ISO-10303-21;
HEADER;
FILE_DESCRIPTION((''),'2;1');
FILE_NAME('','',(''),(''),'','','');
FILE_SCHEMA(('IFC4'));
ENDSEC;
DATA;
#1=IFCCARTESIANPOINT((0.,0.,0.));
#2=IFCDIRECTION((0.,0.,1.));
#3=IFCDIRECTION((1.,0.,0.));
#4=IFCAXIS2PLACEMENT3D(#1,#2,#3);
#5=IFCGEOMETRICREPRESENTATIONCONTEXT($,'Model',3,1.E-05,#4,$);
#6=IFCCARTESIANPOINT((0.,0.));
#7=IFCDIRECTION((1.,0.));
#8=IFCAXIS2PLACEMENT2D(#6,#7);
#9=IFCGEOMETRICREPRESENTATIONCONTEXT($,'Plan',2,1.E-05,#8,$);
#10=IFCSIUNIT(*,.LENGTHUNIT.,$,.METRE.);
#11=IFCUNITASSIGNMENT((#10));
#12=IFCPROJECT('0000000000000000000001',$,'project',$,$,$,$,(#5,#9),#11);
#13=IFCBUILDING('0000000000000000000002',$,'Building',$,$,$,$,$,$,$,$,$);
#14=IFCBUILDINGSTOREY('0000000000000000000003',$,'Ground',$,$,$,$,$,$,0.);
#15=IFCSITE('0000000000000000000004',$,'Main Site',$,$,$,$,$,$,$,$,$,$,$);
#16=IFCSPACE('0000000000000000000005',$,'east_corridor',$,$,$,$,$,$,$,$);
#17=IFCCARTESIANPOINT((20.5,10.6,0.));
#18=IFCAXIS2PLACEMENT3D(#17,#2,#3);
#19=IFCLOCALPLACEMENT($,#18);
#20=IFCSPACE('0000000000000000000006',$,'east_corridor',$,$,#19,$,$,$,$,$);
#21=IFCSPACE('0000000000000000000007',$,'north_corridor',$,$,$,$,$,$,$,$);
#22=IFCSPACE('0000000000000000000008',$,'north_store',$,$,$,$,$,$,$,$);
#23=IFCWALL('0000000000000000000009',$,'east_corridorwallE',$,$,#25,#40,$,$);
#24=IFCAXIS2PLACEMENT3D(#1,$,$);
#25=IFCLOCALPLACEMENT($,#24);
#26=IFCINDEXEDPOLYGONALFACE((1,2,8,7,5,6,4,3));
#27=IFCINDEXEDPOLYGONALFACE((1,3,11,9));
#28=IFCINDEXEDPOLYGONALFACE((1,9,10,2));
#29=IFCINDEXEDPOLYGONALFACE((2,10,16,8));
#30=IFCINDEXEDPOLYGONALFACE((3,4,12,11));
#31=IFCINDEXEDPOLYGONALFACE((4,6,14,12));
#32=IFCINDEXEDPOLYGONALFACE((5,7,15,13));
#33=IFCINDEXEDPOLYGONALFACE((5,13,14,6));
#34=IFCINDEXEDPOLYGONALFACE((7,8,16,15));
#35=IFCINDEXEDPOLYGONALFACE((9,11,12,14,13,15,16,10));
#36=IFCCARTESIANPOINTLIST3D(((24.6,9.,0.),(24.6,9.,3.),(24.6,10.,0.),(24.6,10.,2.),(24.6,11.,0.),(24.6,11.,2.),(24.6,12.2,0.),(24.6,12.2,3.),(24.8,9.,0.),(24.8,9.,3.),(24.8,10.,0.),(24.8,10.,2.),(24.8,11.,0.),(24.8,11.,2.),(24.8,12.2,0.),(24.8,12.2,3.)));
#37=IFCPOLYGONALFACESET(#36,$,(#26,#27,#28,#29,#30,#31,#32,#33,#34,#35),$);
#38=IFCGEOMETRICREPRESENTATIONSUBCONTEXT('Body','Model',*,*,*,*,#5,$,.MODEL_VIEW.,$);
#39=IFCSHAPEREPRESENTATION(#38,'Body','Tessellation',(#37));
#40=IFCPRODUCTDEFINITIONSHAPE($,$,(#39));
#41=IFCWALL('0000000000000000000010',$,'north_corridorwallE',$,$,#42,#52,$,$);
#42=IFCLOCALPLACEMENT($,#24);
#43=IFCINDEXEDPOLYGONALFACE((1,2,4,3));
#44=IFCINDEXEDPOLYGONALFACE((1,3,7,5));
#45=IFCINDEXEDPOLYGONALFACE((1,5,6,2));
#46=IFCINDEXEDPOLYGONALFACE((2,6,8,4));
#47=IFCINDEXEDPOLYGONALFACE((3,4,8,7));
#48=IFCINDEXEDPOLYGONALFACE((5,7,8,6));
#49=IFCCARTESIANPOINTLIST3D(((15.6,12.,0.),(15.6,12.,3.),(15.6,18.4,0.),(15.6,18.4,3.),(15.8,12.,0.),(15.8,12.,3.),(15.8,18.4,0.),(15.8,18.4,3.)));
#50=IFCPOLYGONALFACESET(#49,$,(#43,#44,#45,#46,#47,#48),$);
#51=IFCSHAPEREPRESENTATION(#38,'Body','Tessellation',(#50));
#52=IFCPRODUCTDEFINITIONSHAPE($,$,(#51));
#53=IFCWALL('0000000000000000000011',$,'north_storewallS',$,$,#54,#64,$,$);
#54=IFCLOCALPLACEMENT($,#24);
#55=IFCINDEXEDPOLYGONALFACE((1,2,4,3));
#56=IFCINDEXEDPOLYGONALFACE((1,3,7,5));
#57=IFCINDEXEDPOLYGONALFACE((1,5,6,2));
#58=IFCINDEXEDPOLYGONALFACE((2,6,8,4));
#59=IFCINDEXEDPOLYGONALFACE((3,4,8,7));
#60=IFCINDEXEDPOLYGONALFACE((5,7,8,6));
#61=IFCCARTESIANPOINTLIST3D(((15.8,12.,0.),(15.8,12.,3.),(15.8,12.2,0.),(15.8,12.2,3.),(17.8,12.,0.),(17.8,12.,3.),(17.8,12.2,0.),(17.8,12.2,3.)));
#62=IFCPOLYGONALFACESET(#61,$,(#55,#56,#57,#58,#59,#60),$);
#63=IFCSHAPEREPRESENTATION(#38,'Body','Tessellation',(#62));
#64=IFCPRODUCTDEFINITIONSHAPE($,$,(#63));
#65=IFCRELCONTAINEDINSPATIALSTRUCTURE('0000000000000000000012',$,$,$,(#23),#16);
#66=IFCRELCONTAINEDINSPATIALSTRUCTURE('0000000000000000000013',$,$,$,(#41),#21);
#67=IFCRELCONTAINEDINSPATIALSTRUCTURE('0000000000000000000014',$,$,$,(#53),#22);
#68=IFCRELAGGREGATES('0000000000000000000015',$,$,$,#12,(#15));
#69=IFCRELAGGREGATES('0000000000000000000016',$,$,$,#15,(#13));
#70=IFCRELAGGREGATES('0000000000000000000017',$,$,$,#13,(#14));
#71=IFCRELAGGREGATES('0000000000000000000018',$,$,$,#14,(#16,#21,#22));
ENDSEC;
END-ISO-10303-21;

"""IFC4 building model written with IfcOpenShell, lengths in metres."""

from ifc_helpers import new_model, si_unit, frame, origin_with_axes, origin_2d_with_axis, place, context, subcontext, project, spatial, indexed_curve, outline, extrude, element, save


model = new_model("IFC4")

# Units and contexts
model_context = context("Model", 3, precision=1e-05, world=origin_with_axes())
plan_context = context("Plan", 2, precision=1e-05, world=origin_2d_with_axis())
body_context = subcontext(model_context, "Body", "Model", "MODEL_VIEW")
ifc_project = project(units=[si_unit("LENGTHUNIT", "METRE")], contexts=[model_context, plan_context])

# Site, building, storey
site = spatial("IfcSite", under=ifc_project, Name="Main Site")
building = spatial("IfcBuilding", under=site, Name="Building")
storey = spatial("IfcBuildingStorey", under=building, Name="Ground", Elevation=0.0)

# Shared definitions
space_1 = spatial("IfcSpace", under=storey, Name="east_corridor")

# Shared definitions
space_2_placement = place(None, frame((20.5, 10.6, 0.0), z_axis=(0.0, 0.0, 1.0), x_axis=(1.0, 0.0, 0.0)))
space_2 = spatial("IfcSpace", at=space_2_placement, Name="east_corridor")

# Wall, opening
wall_1_placement = place(None, frame((24.8, 9.0, 0.0), z_axis=(0.0, 0.0, 1.0), x_axis=(0.0, 1.0, 0.0)))
wall_1 = element("IfcWall", 1, at=wall_1_placement, inside=space_1, Name="east_corridorwallE", context=body_context, shape_type="SweptSolid", body=[
    extrude(outline(indexed_curve([(0.0, 0.0), (0.0, 0.2), (3.2, 0.2), (3.2, 0.0), (0.0, 0.0)], self_intersect=False)), origin_with_axes(), (0.0, 0.0, 1.0), 3.0),
])
opening_1_placement = place(wall_1_placement, frame((1.0, 0.0, 0.0), z_axis=(0.0, 0.0, 1.0), x_axis=(1.0, 0.0, 0.0)))
element("IfcOpeningElement", 2, at=opening_1_placement, inside=space_2, cuts=wall_1, context=body_context, shape_type="SweptSolid", body=[
    extrude(outline(indexed_curve([(0.0, 0.0), (0.0, 0.4), (1.0, 0.4), (1.0, 0.0), (0.0, 0.0)], self_intersect=False)), origin_with_axes(), (0.0, 0.0, 1.0), 2.0),
])

# Shared definitions
space_3 = spatial("IfcSpace", under=storey, Name="north_corridor")

# Wall
wall_2_placement = place(None, frame((15.8, 12.0, 0.0), z_axis=(0.0, 0.0, 1.0), x_axis=(0.0, 1.0, 0.0)))
element("IfcWall", 3, at=wall_2_placement, inside=space_3, Name="north_corridorwallE", context=body_context, shape_type="SweptSolid", body=[
    extrude(outline(indexed_curve([(0.0, 0.0), (0.0, 0.2), (6.4, 0.2), (6.4, 0.0), (0.0, 0.0)], self_intersect=False)), origin_with_axes(), (0.0, 0.0, 1.0), 3.0),
])

# Shared definitions
space_4 = spatial("IfcSpace", under=storey, Name="north_store")

# Wall
wall_3_placement = place(None, frame((15.8, 12.0, 0.0), z_axis=(0.0, 0.0, 1.0), x_axis=(1.0, 0.0, 0.0)))
element("IfcWall", 4, at=wall_3_placement, inside=space_4, Name="north_storewallS", context=body_context, shape_type="SweptSolid", body=[
    extrude(outline(indexed_curve([(0.0, 0.0), (0.0, 0.2), (2.0, 0.2), (2.0, 0.0), (0.0, 0.0)], self_intersect=False)), origin_with_axes(), (0.0, 0.0, 1.0), 3.0),
])

save(model, "model.ifc")
